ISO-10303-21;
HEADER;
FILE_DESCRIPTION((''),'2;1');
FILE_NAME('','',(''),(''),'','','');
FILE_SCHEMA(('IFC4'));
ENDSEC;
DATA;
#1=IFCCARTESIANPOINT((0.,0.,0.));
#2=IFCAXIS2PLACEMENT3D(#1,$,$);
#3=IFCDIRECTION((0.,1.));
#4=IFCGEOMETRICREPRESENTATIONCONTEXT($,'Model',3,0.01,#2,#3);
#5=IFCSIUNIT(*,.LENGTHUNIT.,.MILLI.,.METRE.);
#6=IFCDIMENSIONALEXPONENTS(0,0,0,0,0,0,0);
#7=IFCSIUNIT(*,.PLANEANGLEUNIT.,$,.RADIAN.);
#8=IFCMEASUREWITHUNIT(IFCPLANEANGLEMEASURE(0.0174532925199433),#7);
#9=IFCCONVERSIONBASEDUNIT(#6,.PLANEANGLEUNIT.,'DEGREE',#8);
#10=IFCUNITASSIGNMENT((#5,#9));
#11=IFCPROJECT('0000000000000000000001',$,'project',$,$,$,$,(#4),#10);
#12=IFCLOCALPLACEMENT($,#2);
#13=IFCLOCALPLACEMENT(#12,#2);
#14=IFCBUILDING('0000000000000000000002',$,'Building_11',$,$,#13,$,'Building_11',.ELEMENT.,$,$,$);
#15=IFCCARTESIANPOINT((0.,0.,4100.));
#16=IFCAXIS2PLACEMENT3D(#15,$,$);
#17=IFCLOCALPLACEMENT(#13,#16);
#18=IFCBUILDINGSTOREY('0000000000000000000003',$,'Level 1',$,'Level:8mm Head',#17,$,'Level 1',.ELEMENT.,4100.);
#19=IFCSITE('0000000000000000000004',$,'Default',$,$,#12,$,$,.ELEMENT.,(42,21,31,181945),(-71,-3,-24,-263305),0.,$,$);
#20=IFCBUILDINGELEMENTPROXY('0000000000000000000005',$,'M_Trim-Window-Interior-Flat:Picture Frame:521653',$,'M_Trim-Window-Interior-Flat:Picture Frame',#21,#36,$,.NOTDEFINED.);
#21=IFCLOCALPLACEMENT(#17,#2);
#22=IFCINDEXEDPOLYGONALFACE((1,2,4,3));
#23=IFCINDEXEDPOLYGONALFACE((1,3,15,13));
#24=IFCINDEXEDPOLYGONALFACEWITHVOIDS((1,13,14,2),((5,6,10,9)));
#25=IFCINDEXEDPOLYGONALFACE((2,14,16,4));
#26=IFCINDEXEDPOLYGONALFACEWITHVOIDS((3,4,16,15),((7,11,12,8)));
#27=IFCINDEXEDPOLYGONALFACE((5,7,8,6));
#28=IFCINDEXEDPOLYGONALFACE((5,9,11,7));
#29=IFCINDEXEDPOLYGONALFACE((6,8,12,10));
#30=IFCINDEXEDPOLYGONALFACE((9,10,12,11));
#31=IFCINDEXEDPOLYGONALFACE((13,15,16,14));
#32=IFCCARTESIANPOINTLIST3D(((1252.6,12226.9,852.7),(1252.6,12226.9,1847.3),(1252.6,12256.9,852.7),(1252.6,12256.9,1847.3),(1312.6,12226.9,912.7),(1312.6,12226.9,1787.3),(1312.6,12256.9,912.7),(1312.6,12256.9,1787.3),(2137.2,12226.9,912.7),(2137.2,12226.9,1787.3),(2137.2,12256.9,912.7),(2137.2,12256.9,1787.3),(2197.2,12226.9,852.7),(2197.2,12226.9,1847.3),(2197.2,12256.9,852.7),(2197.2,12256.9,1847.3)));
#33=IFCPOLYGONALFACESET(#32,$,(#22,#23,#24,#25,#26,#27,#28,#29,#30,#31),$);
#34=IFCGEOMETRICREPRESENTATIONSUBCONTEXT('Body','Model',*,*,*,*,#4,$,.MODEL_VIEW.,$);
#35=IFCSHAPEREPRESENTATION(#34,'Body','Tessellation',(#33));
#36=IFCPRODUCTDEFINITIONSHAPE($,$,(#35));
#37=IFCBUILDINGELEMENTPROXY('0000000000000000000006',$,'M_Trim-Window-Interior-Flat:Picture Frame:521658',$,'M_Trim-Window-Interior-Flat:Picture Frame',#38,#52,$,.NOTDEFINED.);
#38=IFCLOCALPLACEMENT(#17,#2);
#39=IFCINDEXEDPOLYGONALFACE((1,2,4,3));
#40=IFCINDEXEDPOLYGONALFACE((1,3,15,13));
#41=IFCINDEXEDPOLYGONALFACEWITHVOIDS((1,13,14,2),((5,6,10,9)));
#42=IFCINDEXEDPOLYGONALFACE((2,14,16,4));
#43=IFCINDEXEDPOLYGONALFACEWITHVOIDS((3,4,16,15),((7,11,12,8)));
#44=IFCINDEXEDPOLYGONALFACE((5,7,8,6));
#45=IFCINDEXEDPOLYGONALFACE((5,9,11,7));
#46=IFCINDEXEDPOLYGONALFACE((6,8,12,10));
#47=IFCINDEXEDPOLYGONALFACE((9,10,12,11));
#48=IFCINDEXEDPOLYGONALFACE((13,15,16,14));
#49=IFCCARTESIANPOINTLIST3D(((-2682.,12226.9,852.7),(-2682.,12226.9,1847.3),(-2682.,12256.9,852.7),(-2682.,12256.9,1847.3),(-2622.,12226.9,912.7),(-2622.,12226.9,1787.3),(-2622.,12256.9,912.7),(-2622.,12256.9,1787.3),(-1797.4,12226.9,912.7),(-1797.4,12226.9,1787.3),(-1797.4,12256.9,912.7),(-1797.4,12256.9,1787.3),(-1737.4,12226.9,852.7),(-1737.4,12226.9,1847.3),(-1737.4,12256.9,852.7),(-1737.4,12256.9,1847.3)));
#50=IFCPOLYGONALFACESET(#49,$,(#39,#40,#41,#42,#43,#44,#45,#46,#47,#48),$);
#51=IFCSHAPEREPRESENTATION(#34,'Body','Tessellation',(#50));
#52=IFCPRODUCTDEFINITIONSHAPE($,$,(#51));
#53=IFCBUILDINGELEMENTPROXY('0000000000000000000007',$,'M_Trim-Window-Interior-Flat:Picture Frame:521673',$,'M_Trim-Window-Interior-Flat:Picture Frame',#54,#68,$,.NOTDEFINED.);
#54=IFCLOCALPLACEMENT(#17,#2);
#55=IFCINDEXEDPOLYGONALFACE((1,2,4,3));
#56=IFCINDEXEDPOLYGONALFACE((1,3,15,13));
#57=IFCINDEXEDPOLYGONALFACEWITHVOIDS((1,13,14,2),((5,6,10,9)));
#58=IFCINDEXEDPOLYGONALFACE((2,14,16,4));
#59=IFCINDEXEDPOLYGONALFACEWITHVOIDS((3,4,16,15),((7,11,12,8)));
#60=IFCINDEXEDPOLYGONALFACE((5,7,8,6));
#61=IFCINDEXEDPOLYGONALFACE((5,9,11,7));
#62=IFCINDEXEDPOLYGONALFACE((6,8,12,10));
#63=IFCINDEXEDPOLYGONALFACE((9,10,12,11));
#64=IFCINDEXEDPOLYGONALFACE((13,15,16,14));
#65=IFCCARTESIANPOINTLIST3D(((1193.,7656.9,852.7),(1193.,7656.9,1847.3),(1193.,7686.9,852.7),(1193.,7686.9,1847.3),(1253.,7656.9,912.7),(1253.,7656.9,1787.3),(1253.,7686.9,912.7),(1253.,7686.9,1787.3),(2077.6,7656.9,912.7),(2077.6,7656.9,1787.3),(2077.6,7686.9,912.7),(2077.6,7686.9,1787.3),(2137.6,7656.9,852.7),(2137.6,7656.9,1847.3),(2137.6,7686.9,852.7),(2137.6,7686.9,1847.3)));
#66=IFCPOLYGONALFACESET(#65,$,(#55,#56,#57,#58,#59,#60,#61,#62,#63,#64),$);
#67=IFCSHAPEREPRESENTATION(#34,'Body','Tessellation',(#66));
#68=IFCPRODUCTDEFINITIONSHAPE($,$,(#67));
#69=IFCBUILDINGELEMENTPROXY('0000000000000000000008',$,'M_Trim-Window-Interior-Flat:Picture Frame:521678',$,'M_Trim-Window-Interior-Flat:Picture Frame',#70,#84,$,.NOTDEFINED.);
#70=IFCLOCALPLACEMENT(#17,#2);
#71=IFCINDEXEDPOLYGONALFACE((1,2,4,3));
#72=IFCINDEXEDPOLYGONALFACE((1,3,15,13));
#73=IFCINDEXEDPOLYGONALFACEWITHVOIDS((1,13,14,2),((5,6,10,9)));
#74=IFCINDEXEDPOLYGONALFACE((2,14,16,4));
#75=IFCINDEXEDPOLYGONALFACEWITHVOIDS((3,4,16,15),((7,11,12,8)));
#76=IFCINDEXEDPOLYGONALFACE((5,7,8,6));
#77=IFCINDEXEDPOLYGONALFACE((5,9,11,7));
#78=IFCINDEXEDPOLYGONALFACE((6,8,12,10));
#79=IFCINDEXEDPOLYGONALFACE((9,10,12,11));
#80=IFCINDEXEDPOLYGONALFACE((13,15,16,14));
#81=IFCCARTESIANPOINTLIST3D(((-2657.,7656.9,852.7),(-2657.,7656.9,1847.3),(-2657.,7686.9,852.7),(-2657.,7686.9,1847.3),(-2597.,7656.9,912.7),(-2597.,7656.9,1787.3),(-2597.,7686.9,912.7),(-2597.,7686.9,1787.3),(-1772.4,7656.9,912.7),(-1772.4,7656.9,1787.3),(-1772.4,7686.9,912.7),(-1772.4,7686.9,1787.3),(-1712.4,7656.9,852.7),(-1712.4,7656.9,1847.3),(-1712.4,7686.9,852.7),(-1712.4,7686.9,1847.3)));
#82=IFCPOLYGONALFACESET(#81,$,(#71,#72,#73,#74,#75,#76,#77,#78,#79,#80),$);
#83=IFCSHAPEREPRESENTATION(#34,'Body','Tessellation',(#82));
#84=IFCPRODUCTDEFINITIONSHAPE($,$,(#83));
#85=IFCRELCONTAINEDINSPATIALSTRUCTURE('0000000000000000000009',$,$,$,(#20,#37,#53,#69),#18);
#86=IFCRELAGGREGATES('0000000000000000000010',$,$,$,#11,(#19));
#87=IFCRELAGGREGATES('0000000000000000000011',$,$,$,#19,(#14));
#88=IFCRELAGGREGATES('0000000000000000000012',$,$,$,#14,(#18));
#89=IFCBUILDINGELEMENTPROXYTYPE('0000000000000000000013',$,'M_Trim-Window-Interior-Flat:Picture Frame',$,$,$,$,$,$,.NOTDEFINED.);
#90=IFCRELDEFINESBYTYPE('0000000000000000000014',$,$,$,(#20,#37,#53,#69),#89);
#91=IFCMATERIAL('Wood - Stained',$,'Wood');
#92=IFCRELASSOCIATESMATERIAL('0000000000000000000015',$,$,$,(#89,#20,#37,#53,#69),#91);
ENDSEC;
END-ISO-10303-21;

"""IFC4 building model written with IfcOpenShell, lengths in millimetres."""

from ifc_helpers import new_model, entity, si_unit, converted_unit, direction, frame, origin, place, context, subcontext, project, spatial, indexed_curve, outline, extrude, source, transform, mapped, material, type_object, type_shapes, element, save


model = new_model("IFC4")

# Units and contexts
model_context = context("Model", 3, precision=0.01, world=origin(), true_north=direction((0.0, 1.0)))
body_context = subcontext(model_context, "Body", "Model", "MODEL_VIEW")
ifc_project = project(units=[si_unit("LENGTHUNIT", "METRE", prefix="MILLI"), converted_unit("PLANEANGLEUNIT", "DEGREE", entity("IfcPlaneAngleMeasure", 0.0174532925199433), si_unit("PLANEANGLEUNIT", "RADIAN"), dimensions=[0, 0, 0, 0, 0, 0, 0])], contexts=[model_context])

# Site, building, storey
site_placement = place(None, origin())
site = spatial("IfcSite", under=ifc_project, at=site_placement, Name="Default", CompositionType="ELEMENT", RefLatitude=(42, 21, 31, 181945), RefLongitude=(-71, -3, -24, -263305), RefElevation=0.0)
building_placement = place(site_placement, origin())
building = spatial("IfcBuilding", under=site, at=building_placement, Name="Building_11", LongName="Building_11", CompositionType="ELEMENT")
storey_placement = place(building_placement, frame((0.0, 0.0, 4100.0)))
storey = spatial("IfcBuildingStorey", under=building, at=storey_placement, Name="Level 1", ObjectType="Level:8mm Head", LongName="Level 1", CompositionType="ELEMENT", Elevation=4100.0)

# Building element proxies
ifc_material_1 = material(Name="Wood - Stained", Category="Wood")
building_element_proxy_type_1 = type_object("IfcBuildingElementProxyType", Name="M_Trim-Window-Interior-Flat:Picture Frame", PredefinedType="NOTDEFINED", material=ifc_material_1)
shared_shape_1 = source(origin(), body_context, "Body", "SweptSolid", [
    extrude(outline(indexed_curve([(-472.3, -497.3), (472.3, -497.3), (472.3, 497.3), (-472.3, 497.3), (-472.3, -497.3)], self_intersect=False), holes=[indexed_curve([(-412.3, -437.3), (-412.3, 437.3), (412.3, 437.3), (412.3, -437.3), (-412.3, -437.3)], self_intersect=False)]), frame((0.0, -450.0, 0.0), z_axis=(0.0, 0.0, 1.0), x_axis=(-1.0, 0.0, 0.0)), (0.0, 0.0, 1.0), 30.0),
])
type_shapes(building_element_proxy_type_1, [shared_shape_1])
for number, where, z_axis, x_axis, name in (
    (1, (1724.9, 12256.9, 1800.0), (0.0, -1.0, 0.0), (1.0, 0.0, 0.0), "M_Trim-Window-Interior-Flat:Picture Frame:521653"),
    (2, (-2209.7, 12256.9, 1800.0), (0.0, -1.0, 0.0), (1.0, 0.0, 0.0), "M_Trim-Window-Interior-Flat:Picture Frame:521658"),
    (3, (1665.3, 7656.9, 1800.0), (0.0, 1.0, 0.0), (-1.0, 0.0, 0.0), "M_Trim-Window-Interior-Flat:Picture Frame:521673"),
    (4, (-2184.7, 7656.9, 1800.0), (0.0, 1.0, 0.0), (-1.0, 0.0, 0.0), "M_Trim-Window-Interior-Flat:Picture Frame:521678"),
):
    element("IfcBuildingElementProxy", number, at=place(storey_placement, frame(where, z_axis=z_axis, x_axis=x_axis)), inside=storey, type_object=building_element_proxy_type_1, material=ifc_material_1, Name=name, ObjectType="M_Trim-Window-Interior-Flat:Picture Frame", PredefinedType="NOTDEFINED", context=body_context, shape_type="MappedRepresentation", body=[
        mapped(shared_shape_1, transform((0.0, 0.0, 0.0), scale=1.0)),
    ])

save(model, "model.ifc")
